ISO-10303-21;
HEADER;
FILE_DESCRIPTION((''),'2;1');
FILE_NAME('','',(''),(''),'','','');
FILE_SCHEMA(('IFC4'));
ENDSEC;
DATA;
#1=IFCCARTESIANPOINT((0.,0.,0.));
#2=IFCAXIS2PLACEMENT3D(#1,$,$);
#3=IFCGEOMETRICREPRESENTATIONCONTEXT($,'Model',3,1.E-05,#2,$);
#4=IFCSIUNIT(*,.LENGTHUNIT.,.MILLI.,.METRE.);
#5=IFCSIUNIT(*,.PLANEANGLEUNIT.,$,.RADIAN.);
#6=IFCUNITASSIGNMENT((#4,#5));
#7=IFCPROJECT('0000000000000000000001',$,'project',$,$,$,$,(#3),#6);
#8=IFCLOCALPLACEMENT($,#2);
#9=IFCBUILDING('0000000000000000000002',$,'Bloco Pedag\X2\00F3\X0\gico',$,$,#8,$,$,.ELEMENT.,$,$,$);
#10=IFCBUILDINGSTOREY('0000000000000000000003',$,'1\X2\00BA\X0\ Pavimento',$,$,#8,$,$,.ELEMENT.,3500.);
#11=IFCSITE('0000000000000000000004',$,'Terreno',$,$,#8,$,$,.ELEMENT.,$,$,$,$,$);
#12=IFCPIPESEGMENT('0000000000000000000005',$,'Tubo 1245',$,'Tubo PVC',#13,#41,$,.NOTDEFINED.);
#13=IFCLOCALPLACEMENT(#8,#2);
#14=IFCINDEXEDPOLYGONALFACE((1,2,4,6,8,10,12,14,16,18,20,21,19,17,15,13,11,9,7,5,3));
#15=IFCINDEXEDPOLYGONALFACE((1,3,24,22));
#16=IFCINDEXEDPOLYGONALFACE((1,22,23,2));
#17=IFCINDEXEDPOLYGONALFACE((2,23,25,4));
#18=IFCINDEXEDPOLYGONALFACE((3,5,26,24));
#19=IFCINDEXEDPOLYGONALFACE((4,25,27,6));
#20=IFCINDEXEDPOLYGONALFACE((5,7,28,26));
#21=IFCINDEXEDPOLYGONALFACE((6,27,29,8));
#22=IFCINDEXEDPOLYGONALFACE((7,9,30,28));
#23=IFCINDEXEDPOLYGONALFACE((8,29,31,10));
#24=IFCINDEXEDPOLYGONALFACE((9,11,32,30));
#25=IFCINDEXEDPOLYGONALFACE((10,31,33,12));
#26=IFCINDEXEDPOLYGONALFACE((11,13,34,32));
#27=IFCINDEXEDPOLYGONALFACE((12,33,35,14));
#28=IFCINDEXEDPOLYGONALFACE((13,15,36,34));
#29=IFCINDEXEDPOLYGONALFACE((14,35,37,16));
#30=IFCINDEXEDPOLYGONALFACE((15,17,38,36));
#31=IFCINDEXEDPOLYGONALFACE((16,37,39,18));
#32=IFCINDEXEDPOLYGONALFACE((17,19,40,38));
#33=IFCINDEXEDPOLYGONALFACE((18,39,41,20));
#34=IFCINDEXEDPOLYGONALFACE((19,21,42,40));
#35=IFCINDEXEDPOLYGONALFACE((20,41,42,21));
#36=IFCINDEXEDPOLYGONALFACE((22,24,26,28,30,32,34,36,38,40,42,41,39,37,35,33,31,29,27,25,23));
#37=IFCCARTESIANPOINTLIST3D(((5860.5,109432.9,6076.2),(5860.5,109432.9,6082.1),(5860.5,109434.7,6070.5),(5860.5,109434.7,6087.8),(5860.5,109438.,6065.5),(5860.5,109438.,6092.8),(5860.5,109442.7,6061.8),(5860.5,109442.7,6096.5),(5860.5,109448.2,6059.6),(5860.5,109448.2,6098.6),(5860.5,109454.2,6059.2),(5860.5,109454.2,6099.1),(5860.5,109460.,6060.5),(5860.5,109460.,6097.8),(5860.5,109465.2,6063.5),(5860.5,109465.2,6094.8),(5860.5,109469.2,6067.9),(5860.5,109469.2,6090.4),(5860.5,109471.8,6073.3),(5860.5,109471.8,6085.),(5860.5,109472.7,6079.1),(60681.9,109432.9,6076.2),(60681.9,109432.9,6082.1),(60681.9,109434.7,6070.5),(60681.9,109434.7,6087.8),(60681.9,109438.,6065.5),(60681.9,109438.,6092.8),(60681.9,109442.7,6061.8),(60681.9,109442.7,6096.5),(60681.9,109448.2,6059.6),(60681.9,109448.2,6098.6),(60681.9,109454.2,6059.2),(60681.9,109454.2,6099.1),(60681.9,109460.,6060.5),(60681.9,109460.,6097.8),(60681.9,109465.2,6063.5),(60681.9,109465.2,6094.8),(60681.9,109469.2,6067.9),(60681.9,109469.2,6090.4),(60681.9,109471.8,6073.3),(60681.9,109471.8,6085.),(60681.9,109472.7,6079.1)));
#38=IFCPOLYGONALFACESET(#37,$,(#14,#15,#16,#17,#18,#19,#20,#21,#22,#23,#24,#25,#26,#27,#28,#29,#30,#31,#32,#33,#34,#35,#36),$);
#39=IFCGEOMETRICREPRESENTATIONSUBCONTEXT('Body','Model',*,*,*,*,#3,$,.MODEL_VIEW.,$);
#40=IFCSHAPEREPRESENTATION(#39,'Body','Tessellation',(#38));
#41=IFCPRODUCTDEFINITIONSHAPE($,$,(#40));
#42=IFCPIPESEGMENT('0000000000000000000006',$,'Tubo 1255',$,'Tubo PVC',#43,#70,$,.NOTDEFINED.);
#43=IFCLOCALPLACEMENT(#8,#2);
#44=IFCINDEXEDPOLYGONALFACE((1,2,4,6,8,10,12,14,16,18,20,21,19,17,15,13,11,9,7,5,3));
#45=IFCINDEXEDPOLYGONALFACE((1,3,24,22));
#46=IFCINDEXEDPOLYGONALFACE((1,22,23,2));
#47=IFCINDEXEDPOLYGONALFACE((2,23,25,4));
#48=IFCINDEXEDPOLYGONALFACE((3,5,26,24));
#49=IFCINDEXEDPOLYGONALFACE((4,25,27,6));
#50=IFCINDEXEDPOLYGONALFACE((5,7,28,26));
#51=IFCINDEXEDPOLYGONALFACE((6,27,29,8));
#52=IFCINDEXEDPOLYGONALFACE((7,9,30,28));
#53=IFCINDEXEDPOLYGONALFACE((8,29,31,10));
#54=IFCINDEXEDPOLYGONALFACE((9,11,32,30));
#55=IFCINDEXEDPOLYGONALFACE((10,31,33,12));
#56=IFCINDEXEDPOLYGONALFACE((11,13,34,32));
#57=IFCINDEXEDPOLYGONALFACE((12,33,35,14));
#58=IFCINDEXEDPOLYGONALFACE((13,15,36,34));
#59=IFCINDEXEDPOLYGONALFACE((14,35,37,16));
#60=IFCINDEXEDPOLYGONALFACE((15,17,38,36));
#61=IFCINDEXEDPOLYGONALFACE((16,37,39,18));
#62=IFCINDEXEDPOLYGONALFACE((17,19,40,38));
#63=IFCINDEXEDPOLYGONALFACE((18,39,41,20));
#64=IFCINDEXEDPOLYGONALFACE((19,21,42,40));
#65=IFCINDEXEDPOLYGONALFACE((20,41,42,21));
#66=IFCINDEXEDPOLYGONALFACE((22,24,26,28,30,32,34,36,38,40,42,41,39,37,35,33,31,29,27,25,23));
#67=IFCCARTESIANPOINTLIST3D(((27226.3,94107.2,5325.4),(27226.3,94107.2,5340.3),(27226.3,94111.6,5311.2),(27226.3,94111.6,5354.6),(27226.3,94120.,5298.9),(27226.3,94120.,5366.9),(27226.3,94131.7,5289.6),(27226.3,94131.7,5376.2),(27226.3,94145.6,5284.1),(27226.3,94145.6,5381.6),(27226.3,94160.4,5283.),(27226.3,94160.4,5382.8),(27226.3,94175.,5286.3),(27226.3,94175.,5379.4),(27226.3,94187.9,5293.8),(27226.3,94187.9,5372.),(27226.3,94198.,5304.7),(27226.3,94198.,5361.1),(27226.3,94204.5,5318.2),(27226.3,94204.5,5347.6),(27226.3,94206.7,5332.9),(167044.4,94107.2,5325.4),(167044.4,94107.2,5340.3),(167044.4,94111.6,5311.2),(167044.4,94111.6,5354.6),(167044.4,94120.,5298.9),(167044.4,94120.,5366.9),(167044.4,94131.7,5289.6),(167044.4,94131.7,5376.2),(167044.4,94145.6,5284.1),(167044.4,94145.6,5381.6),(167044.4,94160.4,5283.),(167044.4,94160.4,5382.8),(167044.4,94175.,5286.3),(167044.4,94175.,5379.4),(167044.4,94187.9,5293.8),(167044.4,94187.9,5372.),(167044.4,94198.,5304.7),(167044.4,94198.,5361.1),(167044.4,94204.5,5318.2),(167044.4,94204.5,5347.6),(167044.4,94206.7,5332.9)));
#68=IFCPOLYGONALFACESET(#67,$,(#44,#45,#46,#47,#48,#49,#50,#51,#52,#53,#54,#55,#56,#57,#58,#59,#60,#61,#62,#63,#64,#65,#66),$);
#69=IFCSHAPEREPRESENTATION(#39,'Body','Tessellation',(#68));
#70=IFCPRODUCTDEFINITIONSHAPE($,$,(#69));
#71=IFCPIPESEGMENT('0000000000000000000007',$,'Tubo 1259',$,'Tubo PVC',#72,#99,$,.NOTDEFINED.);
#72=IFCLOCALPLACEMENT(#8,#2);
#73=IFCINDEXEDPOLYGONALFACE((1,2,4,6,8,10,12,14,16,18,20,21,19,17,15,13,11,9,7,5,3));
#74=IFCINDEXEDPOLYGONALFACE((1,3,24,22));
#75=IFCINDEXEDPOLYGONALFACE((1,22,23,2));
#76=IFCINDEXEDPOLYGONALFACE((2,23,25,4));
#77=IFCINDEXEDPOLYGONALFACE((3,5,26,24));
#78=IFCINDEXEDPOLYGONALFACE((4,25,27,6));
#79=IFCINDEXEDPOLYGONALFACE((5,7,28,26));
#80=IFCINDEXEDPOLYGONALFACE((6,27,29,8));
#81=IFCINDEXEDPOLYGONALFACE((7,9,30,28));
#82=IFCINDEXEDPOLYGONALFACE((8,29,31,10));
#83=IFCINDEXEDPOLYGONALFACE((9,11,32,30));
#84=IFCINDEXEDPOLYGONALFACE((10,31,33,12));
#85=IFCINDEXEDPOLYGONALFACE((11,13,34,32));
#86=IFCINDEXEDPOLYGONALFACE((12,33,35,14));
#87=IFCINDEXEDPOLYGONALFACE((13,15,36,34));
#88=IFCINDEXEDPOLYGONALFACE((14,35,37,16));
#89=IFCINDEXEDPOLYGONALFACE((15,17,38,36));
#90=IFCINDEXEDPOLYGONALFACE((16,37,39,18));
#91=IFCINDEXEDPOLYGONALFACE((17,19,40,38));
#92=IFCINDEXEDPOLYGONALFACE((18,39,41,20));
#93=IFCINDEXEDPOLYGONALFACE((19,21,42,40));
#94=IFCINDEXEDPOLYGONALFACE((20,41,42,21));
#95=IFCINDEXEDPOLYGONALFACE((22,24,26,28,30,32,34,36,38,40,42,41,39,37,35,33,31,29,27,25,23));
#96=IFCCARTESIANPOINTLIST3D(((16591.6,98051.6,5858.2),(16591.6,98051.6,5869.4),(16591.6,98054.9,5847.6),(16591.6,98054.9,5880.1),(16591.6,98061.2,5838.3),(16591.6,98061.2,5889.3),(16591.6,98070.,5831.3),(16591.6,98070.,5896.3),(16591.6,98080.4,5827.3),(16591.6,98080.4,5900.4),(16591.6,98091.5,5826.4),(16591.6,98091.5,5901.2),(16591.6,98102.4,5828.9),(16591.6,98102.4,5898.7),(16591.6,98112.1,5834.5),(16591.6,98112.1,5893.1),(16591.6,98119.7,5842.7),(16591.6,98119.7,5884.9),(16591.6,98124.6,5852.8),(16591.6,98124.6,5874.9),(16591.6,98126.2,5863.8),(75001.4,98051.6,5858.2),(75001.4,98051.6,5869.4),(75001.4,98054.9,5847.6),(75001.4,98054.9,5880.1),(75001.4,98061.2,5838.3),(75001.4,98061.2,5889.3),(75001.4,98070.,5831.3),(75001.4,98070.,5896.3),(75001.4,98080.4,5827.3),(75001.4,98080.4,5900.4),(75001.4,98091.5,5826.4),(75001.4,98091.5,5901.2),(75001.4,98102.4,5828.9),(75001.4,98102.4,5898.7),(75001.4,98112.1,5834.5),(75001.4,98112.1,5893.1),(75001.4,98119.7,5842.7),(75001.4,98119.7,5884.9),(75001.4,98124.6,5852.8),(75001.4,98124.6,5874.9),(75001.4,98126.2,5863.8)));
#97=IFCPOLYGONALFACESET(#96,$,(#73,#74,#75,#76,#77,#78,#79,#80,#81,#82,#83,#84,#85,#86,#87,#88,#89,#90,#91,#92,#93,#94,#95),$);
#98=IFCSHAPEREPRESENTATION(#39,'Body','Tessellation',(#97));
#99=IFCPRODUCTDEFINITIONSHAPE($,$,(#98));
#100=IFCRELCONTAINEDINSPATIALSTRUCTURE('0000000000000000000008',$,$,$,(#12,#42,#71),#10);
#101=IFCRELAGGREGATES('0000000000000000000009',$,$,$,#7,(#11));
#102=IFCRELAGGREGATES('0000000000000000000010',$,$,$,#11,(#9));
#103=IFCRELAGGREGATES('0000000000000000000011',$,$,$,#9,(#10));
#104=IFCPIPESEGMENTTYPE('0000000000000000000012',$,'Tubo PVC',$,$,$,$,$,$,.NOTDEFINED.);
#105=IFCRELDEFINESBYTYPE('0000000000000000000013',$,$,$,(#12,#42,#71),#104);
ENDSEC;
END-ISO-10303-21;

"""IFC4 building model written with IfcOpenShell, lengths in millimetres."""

from ifc_helpers import new_model, si_unit, frame, origin, origin_2d, place, context, subcontext, project, spatial, circle, extrude, type_object, element, save


model = new_model("IFC4")

# Units and contexts
model_context = context("Model", 3, precision=1e-05, world=origin())
body_context = subcontext(model_context, "Body", "Model", "MODEL_VIEW")
ifc_project = project(units=[si_unit("LENGTHUNIT", "METRE", prefix="MILLI"), si_unit("PLANEANGLEUNIT", "RADIAN")], contexts=[model_context])

# Site, building, storey
placement = place(None, origin())
site = spatial("IfcSite", under=ifc_project, at=placement, Name="Terreno", CompositionType="ELEMENT")
building = spatial("IfcBuilding", under=site, at=placement, Name="Bloco Pedagógico", CompositionType="ELEMENT")
storey = spatial("IfcBuildingStorey", under=building, at=placement, Name="1º Pavimento", CompositionType="ELEMENT", Elevation=3500.0)

# Pipe segments
pipe_segment_type = type_object("IfcPipeSegmentType", Name="Tubo PVC", PredefinedType="NOTDEFINED")
pipe_segment_1_placement = place(None, frame((5860.5, 109452.7, 6079.1), z_axis=(1.0, 0.0, 0.0), x_axis=(0.0, 1.0, 0.0)))
element("IfcPipeSegment", 1, at=pipe_segment_1_placement, inside=storey, type_object=pipe_segment_type, Name="Tubo 1245", ObjectType="Tubo PVC", PredefinedType="NOTDEFINED", context=body_context, shape_type="SweptSolid", body=[
    extrude(circle(Radius=20.0, at=origin_2d()), None, (0.0, 0.0, 1.0), 54821.4),
])
pipe_segment_2_placement = place(None, frame((27226.3, 94156.7, 5332.9), z_axis=(1.0, 0.0, 0.0), x_axis=(0.0, 1.0, 0.0)))
element("IfcPipeSegment", 2, at=pipe_segment_2_placement, inside=storey, type_object=pipe_segment_type, Name="Tubo 1255", ObjectType="Tubo PVC", PredefinedType="NOTDEFINED", context=body_context, shape_type="SweptSolid", body=[
    extrude(circle(Radius=50.0, at=origin_2d()), None, (0.0, 0.0, 1.0), 139818.1),
])
pipe_segment_3_placement = place(None, frame((16591.6, 98088.7, 5863.8), z_axis=(1.0, 0.0, 0.0), x_axis=(0.0, 1.0, 0.0)))
element("IfcPipeSegment", 3, at=pipe_segment_3_placement, inside=storey, type_object=pipe_segment_type, Name="Tubo 1259", ObjectType="Tubo PVC", PredefinedType="NOTDEFINED", context=body_context, shape_type="SweptSolid", body=[
    extrude(circle(Radius=37.5, at=origin_2d()), None, (0.0, 0.0, 1.0), 58409.9),
])

save(model, "model.ifc")
